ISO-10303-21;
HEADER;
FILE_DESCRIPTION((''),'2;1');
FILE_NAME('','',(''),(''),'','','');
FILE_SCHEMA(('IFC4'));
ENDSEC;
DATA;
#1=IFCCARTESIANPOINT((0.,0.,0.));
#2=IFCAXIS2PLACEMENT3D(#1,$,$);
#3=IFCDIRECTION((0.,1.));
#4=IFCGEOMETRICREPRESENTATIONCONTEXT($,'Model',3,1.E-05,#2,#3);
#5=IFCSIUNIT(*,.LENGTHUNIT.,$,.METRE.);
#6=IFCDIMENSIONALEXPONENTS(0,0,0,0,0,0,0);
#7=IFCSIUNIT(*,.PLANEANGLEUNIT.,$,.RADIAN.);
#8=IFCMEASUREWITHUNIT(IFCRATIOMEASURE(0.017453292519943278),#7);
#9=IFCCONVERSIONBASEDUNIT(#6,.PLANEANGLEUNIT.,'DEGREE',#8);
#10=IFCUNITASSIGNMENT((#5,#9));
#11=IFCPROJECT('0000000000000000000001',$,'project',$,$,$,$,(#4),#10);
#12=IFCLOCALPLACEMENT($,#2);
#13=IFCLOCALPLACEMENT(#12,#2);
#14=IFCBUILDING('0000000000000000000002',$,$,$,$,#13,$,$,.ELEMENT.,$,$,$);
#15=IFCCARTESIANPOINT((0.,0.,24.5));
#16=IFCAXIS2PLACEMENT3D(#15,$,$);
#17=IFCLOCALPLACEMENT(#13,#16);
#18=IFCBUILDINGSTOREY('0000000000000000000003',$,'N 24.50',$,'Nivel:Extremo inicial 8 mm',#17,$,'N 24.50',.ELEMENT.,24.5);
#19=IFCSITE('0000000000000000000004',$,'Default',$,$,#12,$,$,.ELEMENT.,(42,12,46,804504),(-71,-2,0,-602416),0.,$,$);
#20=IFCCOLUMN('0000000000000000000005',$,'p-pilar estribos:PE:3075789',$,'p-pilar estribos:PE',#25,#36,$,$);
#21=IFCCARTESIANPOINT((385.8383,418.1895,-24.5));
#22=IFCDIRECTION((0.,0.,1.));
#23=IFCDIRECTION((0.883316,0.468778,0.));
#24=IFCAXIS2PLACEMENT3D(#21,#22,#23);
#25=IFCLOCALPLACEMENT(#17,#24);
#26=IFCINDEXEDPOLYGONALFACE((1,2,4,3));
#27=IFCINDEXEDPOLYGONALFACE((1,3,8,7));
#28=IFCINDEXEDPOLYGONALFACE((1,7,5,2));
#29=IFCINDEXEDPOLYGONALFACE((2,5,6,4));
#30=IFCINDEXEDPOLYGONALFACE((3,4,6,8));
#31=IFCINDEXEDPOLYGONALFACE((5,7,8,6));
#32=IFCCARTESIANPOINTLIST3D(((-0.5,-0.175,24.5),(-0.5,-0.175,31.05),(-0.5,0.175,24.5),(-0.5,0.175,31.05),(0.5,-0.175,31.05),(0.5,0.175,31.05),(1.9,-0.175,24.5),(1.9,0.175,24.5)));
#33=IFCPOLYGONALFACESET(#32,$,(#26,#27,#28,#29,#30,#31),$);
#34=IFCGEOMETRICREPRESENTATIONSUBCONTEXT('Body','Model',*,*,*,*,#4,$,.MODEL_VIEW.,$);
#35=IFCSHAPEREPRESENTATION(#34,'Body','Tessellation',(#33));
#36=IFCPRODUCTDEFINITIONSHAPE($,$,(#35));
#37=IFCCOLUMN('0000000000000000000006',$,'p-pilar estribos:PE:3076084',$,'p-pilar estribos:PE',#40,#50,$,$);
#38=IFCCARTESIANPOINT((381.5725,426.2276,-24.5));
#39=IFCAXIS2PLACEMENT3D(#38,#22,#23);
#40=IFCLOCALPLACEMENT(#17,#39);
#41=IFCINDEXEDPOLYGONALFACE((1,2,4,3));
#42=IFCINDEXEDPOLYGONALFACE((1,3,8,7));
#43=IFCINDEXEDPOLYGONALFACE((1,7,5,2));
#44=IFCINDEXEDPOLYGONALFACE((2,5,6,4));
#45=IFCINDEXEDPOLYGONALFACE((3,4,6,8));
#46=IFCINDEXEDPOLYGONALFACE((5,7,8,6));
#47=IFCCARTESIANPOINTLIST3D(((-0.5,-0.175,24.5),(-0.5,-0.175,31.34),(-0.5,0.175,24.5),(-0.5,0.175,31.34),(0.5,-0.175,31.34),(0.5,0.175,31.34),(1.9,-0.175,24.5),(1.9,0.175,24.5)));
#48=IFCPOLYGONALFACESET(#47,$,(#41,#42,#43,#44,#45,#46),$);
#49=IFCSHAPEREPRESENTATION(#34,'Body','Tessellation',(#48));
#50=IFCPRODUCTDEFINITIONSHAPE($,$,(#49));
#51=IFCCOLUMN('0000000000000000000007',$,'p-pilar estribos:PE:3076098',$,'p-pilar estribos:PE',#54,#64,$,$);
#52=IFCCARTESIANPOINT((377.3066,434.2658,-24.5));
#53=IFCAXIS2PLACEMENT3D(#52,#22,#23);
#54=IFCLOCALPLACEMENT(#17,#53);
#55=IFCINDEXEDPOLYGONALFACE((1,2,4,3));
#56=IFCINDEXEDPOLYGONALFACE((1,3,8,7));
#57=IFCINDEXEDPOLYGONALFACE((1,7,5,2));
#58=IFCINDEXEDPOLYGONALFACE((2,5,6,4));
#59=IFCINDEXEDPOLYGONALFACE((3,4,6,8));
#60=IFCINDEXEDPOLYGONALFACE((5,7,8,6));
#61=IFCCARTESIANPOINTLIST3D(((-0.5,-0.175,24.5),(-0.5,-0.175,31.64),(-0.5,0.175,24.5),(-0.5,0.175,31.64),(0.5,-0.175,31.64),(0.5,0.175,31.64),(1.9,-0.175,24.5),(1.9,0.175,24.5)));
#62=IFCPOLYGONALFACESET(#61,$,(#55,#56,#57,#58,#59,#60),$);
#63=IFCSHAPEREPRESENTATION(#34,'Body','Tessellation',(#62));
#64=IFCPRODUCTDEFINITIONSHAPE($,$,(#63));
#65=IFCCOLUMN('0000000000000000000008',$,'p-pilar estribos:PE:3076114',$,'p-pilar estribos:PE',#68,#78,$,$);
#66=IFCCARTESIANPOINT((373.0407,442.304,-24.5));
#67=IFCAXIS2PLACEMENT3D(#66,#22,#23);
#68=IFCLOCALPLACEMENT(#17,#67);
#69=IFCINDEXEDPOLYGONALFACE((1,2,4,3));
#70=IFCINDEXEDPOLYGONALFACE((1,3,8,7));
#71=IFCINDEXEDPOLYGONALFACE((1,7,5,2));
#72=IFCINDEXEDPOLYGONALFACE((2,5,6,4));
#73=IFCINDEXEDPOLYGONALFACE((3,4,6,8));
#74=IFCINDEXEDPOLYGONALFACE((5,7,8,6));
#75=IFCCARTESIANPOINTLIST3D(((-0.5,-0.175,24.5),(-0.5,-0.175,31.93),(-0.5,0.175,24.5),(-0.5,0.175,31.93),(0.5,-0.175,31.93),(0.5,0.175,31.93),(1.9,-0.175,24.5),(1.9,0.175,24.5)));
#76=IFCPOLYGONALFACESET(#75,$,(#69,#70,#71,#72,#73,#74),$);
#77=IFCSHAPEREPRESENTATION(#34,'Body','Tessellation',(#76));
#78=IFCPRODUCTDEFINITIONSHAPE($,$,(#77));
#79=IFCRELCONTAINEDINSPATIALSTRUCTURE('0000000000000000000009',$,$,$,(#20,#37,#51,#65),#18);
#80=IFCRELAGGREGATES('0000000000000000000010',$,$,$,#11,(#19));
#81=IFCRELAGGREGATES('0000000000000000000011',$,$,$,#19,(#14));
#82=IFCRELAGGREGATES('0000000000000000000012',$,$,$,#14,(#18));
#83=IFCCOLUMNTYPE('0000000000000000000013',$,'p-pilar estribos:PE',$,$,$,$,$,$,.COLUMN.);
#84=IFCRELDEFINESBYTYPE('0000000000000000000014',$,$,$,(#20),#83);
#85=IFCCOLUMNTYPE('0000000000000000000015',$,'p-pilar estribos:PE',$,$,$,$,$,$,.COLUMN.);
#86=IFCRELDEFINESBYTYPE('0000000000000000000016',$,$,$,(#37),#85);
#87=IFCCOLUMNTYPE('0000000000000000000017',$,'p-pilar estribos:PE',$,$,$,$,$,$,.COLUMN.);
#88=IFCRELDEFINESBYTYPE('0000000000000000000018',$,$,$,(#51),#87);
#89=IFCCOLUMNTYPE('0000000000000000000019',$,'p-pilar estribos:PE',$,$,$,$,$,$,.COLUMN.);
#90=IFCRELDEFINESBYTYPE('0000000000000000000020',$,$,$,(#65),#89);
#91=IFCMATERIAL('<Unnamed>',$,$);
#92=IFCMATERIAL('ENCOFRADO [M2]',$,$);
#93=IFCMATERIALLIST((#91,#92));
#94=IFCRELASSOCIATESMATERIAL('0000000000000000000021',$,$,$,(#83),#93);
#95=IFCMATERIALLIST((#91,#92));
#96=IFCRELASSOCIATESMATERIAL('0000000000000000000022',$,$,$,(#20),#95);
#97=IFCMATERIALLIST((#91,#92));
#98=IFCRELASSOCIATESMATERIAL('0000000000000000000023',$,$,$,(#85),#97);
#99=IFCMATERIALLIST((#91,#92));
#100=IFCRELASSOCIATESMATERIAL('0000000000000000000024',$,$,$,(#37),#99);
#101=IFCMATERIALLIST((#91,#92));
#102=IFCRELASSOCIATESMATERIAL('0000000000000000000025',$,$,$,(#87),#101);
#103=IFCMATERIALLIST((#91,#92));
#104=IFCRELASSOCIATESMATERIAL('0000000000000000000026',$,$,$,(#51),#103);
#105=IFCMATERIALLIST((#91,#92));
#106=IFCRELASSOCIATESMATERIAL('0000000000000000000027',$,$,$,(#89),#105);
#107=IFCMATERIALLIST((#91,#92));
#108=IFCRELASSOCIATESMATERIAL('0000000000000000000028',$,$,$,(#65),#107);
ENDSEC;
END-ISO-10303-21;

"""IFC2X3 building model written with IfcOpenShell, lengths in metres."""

from ifc_helpers import new_model, entity, si_unit, converted_unit, direction, frame, origin, origin_2d_with_axis, place, context, subcontext, project, spatial, rectangle, extrude, clip, halfspace, source, transform, mapped, material, material_list, type_object, type_shapes, element, save


model = new_model("IFC2X3")

# Units and contexts
model_context = context("Model", 3, precision=1e-05, world=origin(), true_north=direction((0.0, 1.0)))
body_context = subcontext(model_context, "Body", "Model", "MODEL_VIEW")
ifc_project = project(units=[si_unit("LENGTHUNIT", "METRE"), converted_unit("PLANEANGLEUNIT", "DEGREE", entity("IfcRatioMeasure", 0.017453292519943278), si_unit("PLANEANGLEUNIT", "RADIAN"), dimensions=[0, 0, 0, 0, 0, 0, 0])], contexts=[model_context])

# Site, building, storey
site_placement = place(None, origin())
site = spatial("IfcSite", under=ifc_project, at=site_placement, Name="Default", CompositionType="ELEMENT", RefLatitude=(42, 12, 46, 804504), RefLongitude=(-71, -2, 0, -602416), RefElevation=0.0)
building_placement = place(site_placement, origin())
building = spatial("IfcBuilding", under=site, at=building_placement, CompositionType="ELEMENT")
storey_placement = place(building_placement, frame((0.0, 0.0, 24.5)))
storey = spatial("IfcBuildingStorey", under=building, at=storey_placement, Name="N 24.50", ObjectType="Nivel:Extremo inicial 8 mm", LongName="N 24.50", CompositionType="ELEMENT", Elevation=24.5)

# Columns
ifc_material_1 = material(Name="<Unnamed>")
ifc_material_2 = material(Name="ENCOFRADO [M2]")
ifc_material_list_1 = material_list([ifc_material_1, ifc_material_2])
ifc_material_list_2 = material_list([ifc_material_1, ifc_material_2])
column_type_1 = type_object("IfcColumnType", Name="p-pilar estribos:PE", PredefinedType="COLUMN", material=ifc_material_list_2)
shared_shape_1 = source(origin(), body_context, "Body", "SweptSolid", [
    clip(extrude(rectangle(XDim=0.35, YDim=2.4, at=origin_2d_with_axis()), frame((0.7, 0.0, 24.5), z_axis=(0.0, 0.0, 1.0), x_axis=(0.0, -1.0, 0.0)), (0.0, 0.0, 1.0), 6.55), halfspace(frame((1.9, 0.0, 24.5), z_axis=(0.977912, 0.0, 0.209019), x_axis=(0.0, 1.0, 0.0)), False)),
])
type_shapes(column_type_1, [shared_shape_1])
column_1_placement = place(storey_placement, frame((385.8383, 418.1895, -24.5), z_axis=(0.0, 0.0, 1.0), x_axis=(0.883316, 0.468778, 0.0)))
element("IfcColumn", 1, at=column_1_placement, inside=storey, type_object=column_type_1, material=ifc_material_list_1, Name="p-pilar estribos:PE:3075789", ObjectType="p-pilar estribos:PE", context=body_context, shape_type="MappedRepresentation", body=[
    mapped(shared_shape_1, transform((0.0, 0.0, 0.0), scale=1.0)),
])
ifc_material_list_3 = material_list([ifc_material_1, ifc_material_2])
ifc_material_list_4 = material_list([ifc_material_1, ifc_material_2])
column_type_2 = type_object("IfcColumnType", Name="p-pilar estribos:PE", PredefinedType="COLUMN", material=ifc_material_list_4)
shared_shape_2 = source(origin(), body_context, "Body", "SweptSolid", [
    clip(extrude(rectangle(XDim=0.35, YDim=2.4, at=origin_2d_with_axis()), frame((0.7, 0.0, 24.5), z_axis=(0.0, 0.0, 1.0), x_axis=(0.0, -1.0, 0.0)), (0.0, 0.0, 1.0), 6.84), halfspace(frame((1.9, 0.0, 24.5), z_axis=(0.979689, 0.0, 0.200521), x_axis=(0.0, 1.0, 0.0)), False)),
])
type_shapes(column_type_2, [shared_shape_2])
column_2_placement = place(storey_placement, frame((381.5725, 426.2276, -24.5), z_axis=(0.0, 0.0, 1.0), x_axis=(0.883316, 0.468778, 0.0)))
element("IfcColumn", 2, at=column_2_placement, inside=storey, type_object=column_type_2, material=ifc_material_list_3, Name="p-pilar estribos:PE:3076084", ObjectType="p-pilar estribos:PE", context=body_context, shape_type="MappedRepresentation", body=[
    mapped(shared_shape_2, transform((0.0, 0.0, 0.0), scale=1.0)),
])
ifc_material_list_5 = material_list([ifc_material_1, ifc_material_2])
ifc_material_list_6 = material_list([ifc_material_1, ifc_material_2])
column_type_3 = type_object("IfcColumnType", Name="p-pilar estribos:PE", PredefinedType="COLUMN", material=ifc_material_list_6)
shared_shape_3 = source(origin(), body_context, "Body", "SweptSolid", [
    clip(extrude(rectangle(XDim=0.35, YDim=2.4, at=origin_2d_with_axis()), frame((0.7, 0.0, 24.5), z_axis=(0.0, 0.0, 1.0), x_axis=(0.0, -1.0, 0.0)), (0.0, 0.0, 1.0), 7.14), halfspace(frame((1.9, 0.0, 24.5), z_axis=(0.981314, 0.0, 0.192414), x_axis=(0.0, 1.0, 0.0)), False)),
])
type_shapes(column_type_3, [shared_shape_3])
column_3_placement = place(storey_placement, frame((377.3066, 434.2658, -24.5), z_axis=(0.0, 0.0, 1.0), x_axis=(0.883316, 0.468778, 0.0)))
element("IfcColumn", 3, at=column_3_placement, inside=storey, type_object=column_type_3, material=ifc_material_list_5, Name="p-pilar estribos:PE:3076098", ObjectType="p-pilar estribos:PE", context=body_context, shape_type="MappedRepresentation", body=[
    mapped(shared_shape_3, transform((0.0, 0.0, 0.0), scale=1.0)),
])
ifc_material_list_7 = material_list([ifc_material_1, ifc_material_2])
ifc_material_list_8 = material_list([ifc_material_1, ifc_material_2])
column_type_4 = type_object("IfcColumnType", Name="p-pilar estribos:PE", PredefinedType="COLUMN", material=ifc_material_list_8)
shared_shape_4 = source(origin(), body_context, "Body", "SweptSolid", [
    clip(extrude(rectangle(XDim=0.35, YDim=2.4, at=origin_2d_with_axis()), frame((0.7, 0.0, 24.5), z_axis=(0.0, 0.0, 1.0), x_axis=(0.0, -1.0, 0.0)), (0.0, 0.0, 1.0), 7.43), halfspace(frame((1.9, 0.0, 24.5), z_axis=(0.982707, 0.0, 0.185167), x_axis=(0.0, 1.0, 0.0)), False)),
])
type_shapes(column_type_4, [shared_shape_4])
column_4_placement = place(storey_placement, frame((373.0407, 442.304, -24.5), z_axis=(0.0, 0.0, 1.0), x_axis=(0.883316, 0.468778, 0.0)))
element("IfcColumn", 4, at=column_4_placement, inside=storey, type_object=column_type_4, material=ifc_material_list_7, Name="p-pilar estribos:PE:3076114", ObjectType="p-pilar estribos:PE", context=body_context, shape_type="MappedRepresentation", body=[
    mapped(shared_shape_4, transform((0.0, 0.0, 0.0), scale=1.0)),
])

save(model, "model.ifc")
